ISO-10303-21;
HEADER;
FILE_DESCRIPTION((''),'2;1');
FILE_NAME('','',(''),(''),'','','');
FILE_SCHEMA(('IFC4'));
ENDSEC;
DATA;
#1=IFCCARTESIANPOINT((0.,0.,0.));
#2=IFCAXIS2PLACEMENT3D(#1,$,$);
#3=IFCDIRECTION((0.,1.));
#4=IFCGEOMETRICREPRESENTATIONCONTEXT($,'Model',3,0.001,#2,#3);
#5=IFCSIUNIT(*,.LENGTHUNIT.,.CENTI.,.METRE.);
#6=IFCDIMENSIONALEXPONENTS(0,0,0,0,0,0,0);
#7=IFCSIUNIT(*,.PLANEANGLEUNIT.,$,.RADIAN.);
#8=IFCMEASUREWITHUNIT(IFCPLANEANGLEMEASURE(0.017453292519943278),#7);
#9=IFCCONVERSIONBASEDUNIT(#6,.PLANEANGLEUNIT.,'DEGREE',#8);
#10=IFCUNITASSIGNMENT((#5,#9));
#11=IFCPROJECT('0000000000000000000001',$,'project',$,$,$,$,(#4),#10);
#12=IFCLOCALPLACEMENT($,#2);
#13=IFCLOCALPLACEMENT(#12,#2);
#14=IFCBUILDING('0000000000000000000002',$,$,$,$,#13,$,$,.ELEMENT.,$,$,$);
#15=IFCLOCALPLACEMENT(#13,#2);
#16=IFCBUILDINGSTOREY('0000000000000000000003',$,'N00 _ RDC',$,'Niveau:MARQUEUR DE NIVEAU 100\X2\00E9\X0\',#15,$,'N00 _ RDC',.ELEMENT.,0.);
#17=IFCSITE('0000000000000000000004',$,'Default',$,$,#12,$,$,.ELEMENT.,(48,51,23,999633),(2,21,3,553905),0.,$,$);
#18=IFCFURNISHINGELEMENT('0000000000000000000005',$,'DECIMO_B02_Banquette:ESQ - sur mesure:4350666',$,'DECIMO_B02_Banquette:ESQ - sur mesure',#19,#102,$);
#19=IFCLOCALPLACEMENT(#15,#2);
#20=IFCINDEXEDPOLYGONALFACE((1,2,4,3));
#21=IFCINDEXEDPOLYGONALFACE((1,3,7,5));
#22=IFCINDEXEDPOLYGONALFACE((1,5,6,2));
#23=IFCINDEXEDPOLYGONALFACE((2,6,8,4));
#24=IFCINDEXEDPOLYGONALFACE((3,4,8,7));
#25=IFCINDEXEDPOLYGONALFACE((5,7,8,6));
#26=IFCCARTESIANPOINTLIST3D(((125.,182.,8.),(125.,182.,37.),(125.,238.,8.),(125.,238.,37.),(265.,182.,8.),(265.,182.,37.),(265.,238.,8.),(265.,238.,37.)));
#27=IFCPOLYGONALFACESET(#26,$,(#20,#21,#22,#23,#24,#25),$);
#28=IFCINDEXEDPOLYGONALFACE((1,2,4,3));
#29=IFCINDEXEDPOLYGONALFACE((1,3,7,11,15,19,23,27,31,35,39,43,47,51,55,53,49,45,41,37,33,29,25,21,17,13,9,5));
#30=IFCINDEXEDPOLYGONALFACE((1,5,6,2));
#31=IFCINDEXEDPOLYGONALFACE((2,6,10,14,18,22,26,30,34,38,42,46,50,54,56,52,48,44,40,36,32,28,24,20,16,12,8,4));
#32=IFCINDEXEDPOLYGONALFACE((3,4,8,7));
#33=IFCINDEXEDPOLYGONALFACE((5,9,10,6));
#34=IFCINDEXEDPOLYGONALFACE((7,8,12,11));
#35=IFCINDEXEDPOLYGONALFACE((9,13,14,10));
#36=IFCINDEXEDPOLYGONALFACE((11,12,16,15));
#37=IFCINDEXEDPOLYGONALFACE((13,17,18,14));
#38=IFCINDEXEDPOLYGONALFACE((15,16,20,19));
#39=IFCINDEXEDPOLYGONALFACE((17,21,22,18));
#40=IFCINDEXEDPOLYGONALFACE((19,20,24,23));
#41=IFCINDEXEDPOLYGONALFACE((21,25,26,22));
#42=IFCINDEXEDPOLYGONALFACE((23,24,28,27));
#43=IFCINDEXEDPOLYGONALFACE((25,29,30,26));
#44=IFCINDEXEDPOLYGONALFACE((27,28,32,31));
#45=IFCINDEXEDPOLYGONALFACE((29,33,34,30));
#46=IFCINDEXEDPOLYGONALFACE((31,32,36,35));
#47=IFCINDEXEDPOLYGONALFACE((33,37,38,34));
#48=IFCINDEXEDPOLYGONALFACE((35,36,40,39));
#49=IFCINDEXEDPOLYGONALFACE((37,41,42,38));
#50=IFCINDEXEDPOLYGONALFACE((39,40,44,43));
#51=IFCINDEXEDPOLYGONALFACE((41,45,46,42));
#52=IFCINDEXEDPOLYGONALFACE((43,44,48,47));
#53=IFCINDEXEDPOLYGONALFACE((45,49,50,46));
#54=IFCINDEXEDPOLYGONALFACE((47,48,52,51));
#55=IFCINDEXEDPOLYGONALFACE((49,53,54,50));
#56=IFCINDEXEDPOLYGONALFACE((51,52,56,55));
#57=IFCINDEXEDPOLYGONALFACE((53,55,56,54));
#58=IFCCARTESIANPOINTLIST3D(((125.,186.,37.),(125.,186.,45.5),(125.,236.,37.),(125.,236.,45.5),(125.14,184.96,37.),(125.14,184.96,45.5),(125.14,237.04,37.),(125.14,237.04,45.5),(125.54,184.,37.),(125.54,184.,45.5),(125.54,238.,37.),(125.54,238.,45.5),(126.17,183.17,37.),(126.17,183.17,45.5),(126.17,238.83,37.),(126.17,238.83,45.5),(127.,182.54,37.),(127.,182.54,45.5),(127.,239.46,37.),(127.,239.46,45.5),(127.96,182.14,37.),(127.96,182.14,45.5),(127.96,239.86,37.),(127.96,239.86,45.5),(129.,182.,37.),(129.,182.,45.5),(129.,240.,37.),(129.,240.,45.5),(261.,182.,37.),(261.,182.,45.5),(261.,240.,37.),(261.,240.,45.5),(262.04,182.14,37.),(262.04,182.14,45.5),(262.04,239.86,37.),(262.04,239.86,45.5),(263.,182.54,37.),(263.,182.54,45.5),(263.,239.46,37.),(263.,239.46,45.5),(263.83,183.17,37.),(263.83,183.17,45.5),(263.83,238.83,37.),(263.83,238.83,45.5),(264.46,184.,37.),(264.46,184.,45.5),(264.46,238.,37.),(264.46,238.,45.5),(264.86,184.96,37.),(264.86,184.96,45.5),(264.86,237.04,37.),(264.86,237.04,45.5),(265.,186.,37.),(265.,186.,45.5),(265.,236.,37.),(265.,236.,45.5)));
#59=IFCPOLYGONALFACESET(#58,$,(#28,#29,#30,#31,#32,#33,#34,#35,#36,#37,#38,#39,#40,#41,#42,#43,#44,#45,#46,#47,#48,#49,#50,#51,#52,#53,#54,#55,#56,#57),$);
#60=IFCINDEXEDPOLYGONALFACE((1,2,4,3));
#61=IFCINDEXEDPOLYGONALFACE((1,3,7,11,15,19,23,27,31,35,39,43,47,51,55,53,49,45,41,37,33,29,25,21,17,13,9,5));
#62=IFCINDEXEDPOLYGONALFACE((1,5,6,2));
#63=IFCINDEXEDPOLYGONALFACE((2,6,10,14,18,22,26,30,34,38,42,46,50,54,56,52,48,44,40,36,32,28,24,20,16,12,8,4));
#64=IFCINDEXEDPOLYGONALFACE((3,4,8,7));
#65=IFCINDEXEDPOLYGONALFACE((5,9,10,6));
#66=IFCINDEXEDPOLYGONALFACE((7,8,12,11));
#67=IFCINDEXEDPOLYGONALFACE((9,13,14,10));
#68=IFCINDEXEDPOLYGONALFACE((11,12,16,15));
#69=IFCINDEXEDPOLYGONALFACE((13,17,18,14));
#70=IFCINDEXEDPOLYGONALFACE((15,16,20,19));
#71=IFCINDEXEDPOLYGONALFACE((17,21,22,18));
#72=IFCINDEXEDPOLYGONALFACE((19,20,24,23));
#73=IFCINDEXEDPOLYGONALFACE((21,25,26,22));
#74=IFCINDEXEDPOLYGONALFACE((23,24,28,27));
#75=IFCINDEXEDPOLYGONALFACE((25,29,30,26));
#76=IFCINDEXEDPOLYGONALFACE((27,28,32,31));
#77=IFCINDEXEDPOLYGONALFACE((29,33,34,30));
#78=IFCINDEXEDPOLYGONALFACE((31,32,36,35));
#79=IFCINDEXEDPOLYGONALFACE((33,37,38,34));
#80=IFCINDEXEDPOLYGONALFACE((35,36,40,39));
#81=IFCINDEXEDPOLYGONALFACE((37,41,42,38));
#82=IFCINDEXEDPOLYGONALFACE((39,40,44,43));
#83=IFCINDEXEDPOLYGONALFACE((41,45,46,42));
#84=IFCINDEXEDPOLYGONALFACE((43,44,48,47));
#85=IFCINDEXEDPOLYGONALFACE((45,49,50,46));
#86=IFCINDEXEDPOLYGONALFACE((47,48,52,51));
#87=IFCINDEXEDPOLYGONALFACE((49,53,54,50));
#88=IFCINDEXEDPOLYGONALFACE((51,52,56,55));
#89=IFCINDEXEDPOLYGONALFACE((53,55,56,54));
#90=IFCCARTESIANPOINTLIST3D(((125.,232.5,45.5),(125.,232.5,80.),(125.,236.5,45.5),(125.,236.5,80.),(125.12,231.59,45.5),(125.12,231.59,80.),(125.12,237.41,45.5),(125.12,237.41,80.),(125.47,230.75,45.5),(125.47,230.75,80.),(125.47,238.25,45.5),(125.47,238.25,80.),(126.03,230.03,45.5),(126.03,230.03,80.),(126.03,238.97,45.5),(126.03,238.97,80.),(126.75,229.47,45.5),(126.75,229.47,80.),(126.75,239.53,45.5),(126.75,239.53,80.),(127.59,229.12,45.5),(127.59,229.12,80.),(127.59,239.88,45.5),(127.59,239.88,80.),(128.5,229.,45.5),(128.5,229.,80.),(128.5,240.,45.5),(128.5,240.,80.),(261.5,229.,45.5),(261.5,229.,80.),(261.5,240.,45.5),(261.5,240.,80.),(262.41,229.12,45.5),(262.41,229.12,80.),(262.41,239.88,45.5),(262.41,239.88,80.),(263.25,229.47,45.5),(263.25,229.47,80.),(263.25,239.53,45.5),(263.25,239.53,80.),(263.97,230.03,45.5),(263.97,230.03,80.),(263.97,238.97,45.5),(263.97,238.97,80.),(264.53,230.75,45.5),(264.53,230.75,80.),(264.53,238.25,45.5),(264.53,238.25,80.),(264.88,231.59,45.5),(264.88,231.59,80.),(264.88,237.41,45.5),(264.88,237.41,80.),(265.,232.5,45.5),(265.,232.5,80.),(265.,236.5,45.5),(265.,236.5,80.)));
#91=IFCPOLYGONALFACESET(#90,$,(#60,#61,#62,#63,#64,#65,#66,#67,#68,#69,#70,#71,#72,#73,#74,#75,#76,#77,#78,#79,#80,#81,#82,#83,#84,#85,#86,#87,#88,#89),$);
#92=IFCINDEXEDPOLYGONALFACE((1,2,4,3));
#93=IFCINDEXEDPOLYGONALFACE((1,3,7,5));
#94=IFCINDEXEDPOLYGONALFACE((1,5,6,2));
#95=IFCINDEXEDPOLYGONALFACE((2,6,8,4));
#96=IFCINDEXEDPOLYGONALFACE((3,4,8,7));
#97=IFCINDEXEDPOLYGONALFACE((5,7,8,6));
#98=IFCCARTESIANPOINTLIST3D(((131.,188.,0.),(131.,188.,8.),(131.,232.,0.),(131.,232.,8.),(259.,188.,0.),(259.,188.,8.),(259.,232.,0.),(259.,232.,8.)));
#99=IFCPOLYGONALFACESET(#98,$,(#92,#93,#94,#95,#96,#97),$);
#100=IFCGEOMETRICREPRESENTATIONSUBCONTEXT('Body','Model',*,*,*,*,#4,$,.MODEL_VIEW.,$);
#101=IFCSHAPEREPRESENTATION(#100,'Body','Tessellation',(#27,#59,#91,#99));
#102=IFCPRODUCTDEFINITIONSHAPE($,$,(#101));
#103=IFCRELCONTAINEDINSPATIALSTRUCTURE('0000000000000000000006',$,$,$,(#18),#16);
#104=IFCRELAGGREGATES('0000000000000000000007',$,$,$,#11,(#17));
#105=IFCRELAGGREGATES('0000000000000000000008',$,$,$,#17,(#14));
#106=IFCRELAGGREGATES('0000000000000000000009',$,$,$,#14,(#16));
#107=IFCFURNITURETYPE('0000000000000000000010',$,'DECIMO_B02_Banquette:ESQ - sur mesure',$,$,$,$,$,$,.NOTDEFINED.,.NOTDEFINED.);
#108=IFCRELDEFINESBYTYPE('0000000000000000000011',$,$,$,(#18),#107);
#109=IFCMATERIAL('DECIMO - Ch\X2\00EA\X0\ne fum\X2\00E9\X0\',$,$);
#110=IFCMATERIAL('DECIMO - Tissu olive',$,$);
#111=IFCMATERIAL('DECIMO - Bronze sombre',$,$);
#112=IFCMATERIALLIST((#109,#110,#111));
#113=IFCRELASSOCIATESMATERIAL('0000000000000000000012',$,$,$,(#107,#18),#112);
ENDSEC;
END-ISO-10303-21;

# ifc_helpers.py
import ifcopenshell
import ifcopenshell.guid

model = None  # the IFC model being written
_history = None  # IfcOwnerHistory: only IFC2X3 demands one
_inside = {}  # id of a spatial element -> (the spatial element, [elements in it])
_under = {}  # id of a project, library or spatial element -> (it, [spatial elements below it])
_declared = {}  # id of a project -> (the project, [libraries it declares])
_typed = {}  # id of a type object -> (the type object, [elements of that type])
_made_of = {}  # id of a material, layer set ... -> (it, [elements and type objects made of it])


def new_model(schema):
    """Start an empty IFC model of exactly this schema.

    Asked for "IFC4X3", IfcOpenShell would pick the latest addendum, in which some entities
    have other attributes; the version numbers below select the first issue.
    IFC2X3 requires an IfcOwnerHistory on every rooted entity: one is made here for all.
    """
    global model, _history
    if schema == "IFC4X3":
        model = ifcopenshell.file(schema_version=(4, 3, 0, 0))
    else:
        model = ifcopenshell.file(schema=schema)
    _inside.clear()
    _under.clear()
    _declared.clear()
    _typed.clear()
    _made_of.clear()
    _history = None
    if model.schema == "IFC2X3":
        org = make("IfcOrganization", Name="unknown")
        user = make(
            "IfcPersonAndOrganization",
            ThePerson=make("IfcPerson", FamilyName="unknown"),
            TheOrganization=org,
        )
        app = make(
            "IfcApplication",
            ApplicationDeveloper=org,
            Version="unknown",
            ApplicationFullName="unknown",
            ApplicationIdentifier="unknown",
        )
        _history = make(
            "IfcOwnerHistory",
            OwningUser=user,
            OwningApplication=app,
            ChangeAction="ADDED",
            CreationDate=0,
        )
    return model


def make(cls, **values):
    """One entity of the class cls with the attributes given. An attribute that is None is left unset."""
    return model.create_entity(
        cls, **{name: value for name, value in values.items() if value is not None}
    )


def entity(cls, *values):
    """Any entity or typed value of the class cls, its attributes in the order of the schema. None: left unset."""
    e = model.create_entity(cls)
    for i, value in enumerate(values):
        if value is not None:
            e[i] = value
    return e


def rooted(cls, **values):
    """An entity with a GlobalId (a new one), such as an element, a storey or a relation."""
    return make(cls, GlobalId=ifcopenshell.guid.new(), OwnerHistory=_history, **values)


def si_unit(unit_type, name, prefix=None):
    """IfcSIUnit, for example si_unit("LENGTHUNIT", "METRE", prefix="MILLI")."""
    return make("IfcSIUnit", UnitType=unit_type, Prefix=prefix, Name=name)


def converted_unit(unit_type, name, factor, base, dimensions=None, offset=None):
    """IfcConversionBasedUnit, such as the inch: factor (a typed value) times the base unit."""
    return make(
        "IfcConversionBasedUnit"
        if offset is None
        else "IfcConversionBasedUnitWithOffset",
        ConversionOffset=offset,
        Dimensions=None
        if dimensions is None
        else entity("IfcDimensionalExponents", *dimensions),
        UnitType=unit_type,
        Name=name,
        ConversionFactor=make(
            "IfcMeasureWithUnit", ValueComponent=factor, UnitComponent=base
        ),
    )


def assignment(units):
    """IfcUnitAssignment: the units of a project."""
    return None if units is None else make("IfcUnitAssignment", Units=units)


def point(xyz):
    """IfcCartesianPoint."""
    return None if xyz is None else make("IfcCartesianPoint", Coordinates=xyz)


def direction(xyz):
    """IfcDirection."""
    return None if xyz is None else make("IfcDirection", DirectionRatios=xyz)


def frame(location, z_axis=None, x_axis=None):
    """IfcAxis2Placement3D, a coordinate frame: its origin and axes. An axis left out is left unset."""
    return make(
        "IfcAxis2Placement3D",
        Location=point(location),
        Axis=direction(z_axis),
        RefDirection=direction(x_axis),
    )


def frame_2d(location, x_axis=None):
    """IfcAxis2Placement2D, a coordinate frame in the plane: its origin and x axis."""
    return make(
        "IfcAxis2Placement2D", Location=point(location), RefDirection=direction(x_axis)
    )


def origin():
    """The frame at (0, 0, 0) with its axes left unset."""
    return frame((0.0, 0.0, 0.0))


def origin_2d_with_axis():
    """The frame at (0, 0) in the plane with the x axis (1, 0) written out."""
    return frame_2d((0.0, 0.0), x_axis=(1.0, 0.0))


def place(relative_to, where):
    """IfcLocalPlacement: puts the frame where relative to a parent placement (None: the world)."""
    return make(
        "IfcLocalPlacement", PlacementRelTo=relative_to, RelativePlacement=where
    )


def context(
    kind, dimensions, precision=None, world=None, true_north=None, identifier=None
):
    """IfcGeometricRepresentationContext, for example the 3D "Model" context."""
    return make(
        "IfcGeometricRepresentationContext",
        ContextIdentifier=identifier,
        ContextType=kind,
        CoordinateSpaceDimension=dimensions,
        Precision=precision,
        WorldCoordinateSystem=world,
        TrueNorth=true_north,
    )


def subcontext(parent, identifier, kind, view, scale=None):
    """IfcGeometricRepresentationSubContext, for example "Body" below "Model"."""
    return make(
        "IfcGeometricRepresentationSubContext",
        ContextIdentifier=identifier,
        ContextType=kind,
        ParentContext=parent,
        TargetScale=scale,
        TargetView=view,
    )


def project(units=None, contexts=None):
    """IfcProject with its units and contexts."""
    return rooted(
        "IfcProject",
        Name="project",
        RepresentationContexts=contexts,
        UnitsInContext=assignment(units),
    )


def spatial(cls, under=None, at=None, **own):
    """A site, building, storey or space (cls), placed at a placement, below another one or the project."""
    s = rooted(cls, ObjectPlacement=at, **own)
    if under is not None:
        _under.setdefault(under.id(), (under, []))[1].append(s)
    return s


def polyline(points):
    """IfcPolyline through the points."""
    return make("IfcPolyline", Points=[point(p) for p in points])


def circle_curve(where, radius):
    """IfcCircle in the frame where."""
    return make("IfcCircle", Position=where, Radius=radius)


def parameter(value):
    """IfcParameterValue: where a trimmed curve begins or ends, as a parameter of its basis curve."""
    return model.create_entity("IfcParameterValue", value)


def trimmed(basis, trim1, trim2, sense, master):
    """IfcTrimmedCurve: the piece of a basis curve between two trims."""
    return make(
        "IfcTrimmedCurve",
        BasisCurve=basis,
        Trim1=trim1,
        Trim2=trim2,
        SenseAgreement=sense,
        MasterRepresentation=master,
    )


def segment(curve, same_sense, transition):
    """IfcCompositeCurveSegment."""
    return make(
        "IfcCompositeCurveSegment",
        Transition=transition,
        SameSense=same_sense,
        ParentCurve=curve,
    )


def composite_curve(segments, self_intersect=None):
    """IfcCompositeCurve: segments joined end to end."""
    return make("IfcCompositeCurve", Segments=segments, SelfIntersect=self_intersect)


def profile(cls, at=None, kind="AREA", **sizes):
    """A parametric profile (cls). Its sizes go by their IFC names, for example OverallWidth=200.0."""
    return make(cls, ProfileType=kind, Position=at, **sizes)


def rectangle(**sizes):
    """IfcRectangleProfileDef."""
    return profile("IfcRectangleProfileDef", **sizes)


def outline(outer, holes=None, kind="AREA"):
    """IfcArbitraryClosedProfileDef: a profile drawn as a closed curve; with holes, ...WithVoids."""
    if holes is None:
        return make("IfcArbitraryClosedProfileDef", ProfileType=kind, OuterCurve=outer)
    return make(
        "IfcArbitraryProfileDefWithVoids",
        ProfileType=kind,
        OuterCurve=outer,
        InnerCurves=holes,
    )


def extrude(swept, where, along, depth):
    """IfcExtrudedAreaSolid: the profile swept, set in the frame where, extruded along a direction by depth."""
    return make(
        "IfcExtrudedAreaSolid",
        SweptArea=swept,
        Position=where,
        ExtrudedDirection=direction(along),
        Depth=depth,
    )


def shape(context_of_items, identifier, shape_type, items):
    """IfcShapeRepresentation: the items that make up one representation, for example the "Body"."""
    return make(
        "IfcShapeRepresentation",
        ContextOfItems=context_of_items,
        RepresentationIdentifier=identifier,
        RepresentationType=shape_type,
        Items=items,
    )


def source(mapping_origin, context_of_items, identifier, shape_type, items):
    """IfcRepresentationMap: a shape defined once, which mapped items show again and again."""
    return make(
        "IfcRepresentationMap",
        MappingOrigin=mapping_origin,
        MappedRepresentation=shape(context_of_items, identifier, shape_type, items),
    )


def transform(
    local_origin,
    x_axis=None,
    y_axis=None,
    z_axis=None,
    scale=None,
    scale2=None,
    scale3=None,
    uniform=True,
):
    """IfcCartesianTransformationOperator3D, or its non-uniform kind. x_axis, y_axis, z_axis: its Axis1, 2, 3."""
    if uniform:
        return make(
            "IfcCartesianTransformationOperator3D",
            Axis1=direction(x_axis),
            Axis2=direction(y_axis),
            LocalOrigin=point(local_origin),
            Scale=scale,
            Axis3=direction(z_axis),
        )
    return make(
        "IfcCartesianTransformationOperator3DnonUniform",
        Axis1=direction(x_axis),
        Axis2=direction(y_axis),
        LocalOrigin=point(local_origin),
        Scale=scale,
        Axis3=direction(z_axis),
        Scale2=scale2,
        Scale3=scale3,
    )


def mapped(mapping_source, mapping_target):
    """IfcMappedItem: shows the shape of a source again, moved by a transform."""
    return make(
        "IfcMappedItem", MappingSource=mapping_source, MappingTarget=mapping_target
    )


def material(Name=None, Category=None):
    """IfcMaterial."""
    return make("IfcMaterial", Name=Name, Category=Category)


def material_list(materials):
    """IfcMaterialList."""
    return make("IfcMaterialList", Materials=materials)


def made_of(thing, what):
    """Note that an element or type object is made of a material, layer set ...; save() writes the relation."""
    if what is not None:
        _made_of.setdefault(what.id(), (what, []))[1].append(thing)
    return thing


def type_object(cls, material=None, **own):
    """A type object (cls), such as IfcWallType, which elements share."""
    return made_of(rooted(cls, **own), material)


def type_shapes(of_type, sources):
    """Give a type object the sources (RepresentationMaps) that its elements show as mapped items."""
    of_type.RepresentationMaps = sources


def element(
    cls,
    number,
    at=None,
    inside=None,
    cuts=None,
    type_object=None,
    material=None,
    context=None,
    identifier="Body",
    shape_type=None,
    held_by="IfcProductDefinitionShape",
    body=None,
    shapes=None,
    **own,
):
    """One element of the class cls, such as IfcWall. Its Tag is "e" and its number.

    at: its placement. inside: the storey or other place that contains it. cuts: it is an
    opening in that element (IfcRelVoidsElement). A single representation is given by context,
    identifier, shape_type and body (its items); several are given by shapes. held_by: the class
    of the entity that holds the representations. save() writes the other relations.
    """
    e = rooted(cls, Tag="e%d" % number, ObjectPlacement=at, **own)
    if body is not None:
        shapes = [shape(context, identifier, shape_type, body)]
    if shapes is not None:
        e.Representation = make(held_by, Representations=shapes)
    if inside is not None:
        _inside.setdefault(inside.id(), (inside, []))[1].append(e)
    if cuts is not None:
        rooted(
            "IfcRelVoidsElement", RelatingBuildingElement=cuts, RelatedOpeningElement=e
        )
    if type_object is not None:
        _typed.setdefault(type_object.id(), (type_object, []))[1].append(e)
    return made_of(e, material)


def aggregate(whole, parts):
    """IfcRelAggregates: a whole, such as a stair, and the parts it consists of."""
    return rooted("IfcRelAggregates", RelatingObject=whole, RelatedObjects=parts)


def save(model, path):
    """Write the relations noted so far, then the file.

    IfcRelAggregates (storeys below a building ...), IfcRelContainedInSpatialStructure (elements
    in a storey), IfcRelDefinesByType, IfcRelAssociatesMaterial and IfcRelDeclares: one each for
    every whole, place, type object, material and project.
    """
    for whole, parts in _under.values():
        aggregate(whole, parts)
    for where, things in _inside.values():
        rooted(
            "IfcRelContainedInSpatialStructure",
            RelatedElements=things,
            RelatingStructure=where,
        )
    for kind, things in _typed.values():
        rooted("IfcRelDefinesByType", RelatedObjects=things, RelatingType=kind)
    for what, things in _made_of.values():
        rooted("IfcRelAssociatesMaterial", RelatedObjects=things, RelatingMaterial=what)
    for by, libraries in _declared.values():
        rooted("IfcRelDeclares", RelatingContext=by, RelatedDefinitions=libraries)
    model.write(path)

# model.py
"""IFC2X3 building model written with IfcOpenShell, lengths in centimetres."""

from ifc_helpers import new_model, entity, si_unit, converted_unit, direction, frame, frame_2d, origin, origin_2d_with_axis, place, context, subcontext, project, spatial, polyline, circle_curve, parameter, trimmed, segment, composite_curve, rectangle, outline, extrude, source, transform, mapped, material, material_list, type_object, type_shapes, element, save


model = new_model("IFC2X3")

# Units and contexts
model_context = context("Model", 3, precision=0.001, world=origin(), true_north=direction((0.0, 1.0)))
body_context = subcontext(model_context, "Body", "Model", "MODEL_VIEW")
ifc_project = project(units=[si_unit("LENGTHUNIT", "METRE", prefix="CENTI"), converted_unit("PLANEANGLEUNIT", "DEGREE", entity("IfcPlaneAngleMeasure", 0.017453292519943278), si_unit("PLANEANGLEUNIT", "RADIAN"), dimensions=[0, 0, 0, 0, 0, 0, 0])], contexts=[model_context])

# Site, building, storey
site_placement = place(None, origin())
site = spatial("IfcSite", under=ifc_project, at=site_placement, Name="Default", CompositionType="ELEMENT", RefLatitude=(48, 51, 23, 999633), RefLongitude=(2, 21, 3, 553905), RefElevation=0.0)
building_placement = place(site_placement, origin())
building = spatial("IfcBuilding", under=site, at=building_placement, CompositionType="ELEMENT")
storey_placement = place(building_placement, origin())
storey = spatial("IfcBuildingStorey", under=building, at=storey_placement, Name="N00 _ RDC", ObjectType="Niveau:MARQUEUR DE NIVEAU 100é", LongName="N00 _ RDC", CompositionType="ELEMENT", Elevation=0.0)

# Furnishing element
ifc_material_1 = material(Name="DECIMO - Bronze sombre")
ifc_material_2 = material(Name="DECIMO - Chêne fumé")
ifc_material_3 = material(Name="DECIMO - Tissu olive")
ifc_material_list_1 = material_list([ifc_material_2, ifc_material_3, ifc_material_1])
furniture_type_1 = type_object("IfcFurnitureType", Name="DECIMO_B02_Banquette:ESQ - sur mesure", AssemblyPlace="NOTDEFINED", material=ifc_material_list_1)
shared_shape_1 = source(origin(), body_context, "Body", "SweptSolid", [
    extrude(rectangle(XDim=140.0, YDim=56.0, at=origin_2d_with_axis()), frame((70.0, 28.0, 8.0)), (0.0, 0.0, 1.0), 29.0),
    extrude(outline(composite_curve([segment(polyline([(-66.0, -29.0), (66.0, -29.0)]), True, "CONTINUOUS"), segment(trimmed(circle_curve(frame_2d((66.0, -25.0), x_axis=(1.0, 0.0)), 4.0), [parameter(270.0)], [parameter(0.0)], True, "PARAMETER"), True, "CONTINUOUS"), segment(polyline([(70.0, -25.0), (70.0, 25.0)]), True, "CONTINUOUS"), segment(trimmed(circle_curve(frame_2d((66.0, 25.0), x_axis=(1.0, 0.0)), 4.0), [parameter(0.0)], [parameter(90.0)], True, "PARAMETER"), True, "CONTINUOUS"), segment(polyline([(66.0, 29.0), (-66.0, 29.0)]), True, "CONTINUOUS"), segment(trimmed(circle_curve(frame_2d((-66.0, 25.0), x_axis=(1.0, 0.0)), 4.0), [parameter(90.0)], [parameter(180.0)], True, "PARAMETER"), True, "CONTINUOUS"), segment(polyline([(-70.0, 25.0), (-70.0, -25.0)]), True, "CONTINUOUS"), segment(trimmed(circle_curve(frame_2d((-66.0, -25.0), x_axis=(1.0, 0.0)), 4.0), [parameter(180.0)], [parameter(270.0)], True, "PARAMETER"), True, "CONTINUOUS")], self_intersect=False)), frame((70.0, 29.0, 37.0)), (0.0, 0.0, 1.0), 8.5),
    extrude(outline(composite_curve([segment(polyline([(-66.5, -5.5), (66.5, -5.5)]), True, "CONTINUOUS"), segment(trimmed(circle_curve(frame_2d((66.5, -2.0), x_axis=(1.0, 0.0)), 3.5), [parameter(270.0)], [parameter(0.0)], True, "PARAMETER"), True, "CONTINUOUS"), segment(polyline([(70.0, -2.0), (70.0, 2.0)]), True, "CONTINUOUS"), segment(trimmed(circle_curve(frame_2d((66.5, 2.0), x_axis=(1.0, 0.0)), 3.5), [parameter(0.0)], [parameter(90.0)], True, "PARAMETER"), True, "CONTINUOUS"), segment(polyline([(66.5, 5.5), (-66.5, 5.5)]), True, "CONTINUOUS"), segment(trimmed(circle_curve(frame_2d((-66.5, 2.0), x_axis=(1.0, 0.0)), 3.5), [parameter(90.0)], [parameter(180.0)], True, "PARAMETER"), True, "CONTINUOUS"), segment(polyline([(-70.0, 2.0), (-70.0, -2.0)]), True, "CONTINUOUS"), segment(trimmed(circle_curve(frame_2d((-66.5, -2.0), x_axis=(1.0, 0.0)), 3.5), [parameter(180.0)], [parameter(270.0)], True, "PARAMETER"), True, "CONTINUOUS")], self_intersect=False)), frame((70.0, 52.5, 45.5)), (0.0, 0.0, 1.0), 34.5),
    extrude(rectangle(XDim=128.0, YDim=44.0, at=frame_2d((0.0, 0.0), x_axis=(1.0, 0.0))), frame((70.0, 28.0, 0.0)), (0.0, 0.0, 1.0), 8.0),
])
type_shapes(furniture_type_1, [shared_shape_1])
furnishing_1_placement = place(storey_placement, frame((125.0, 182.0, 0.0)))
element("IfcFurnishingElement", 1, at=furnishing_1_placement, inside=storey, type_object=furniture_type_1, material=ifc_material_list_1, Name="DECIMO_B02_Banquette:ESQ - sur mesure:4350666", ObjectType="DECIMO_B02_Banquette:ESQ - sur mesure", context=body_context, shape_type="MappedRepresentation", body=[
    mapped(shared_shape_1, transform((0.0, 0.0, 0.0), scale=1.0)),
])

save(model, "model.ifc")
